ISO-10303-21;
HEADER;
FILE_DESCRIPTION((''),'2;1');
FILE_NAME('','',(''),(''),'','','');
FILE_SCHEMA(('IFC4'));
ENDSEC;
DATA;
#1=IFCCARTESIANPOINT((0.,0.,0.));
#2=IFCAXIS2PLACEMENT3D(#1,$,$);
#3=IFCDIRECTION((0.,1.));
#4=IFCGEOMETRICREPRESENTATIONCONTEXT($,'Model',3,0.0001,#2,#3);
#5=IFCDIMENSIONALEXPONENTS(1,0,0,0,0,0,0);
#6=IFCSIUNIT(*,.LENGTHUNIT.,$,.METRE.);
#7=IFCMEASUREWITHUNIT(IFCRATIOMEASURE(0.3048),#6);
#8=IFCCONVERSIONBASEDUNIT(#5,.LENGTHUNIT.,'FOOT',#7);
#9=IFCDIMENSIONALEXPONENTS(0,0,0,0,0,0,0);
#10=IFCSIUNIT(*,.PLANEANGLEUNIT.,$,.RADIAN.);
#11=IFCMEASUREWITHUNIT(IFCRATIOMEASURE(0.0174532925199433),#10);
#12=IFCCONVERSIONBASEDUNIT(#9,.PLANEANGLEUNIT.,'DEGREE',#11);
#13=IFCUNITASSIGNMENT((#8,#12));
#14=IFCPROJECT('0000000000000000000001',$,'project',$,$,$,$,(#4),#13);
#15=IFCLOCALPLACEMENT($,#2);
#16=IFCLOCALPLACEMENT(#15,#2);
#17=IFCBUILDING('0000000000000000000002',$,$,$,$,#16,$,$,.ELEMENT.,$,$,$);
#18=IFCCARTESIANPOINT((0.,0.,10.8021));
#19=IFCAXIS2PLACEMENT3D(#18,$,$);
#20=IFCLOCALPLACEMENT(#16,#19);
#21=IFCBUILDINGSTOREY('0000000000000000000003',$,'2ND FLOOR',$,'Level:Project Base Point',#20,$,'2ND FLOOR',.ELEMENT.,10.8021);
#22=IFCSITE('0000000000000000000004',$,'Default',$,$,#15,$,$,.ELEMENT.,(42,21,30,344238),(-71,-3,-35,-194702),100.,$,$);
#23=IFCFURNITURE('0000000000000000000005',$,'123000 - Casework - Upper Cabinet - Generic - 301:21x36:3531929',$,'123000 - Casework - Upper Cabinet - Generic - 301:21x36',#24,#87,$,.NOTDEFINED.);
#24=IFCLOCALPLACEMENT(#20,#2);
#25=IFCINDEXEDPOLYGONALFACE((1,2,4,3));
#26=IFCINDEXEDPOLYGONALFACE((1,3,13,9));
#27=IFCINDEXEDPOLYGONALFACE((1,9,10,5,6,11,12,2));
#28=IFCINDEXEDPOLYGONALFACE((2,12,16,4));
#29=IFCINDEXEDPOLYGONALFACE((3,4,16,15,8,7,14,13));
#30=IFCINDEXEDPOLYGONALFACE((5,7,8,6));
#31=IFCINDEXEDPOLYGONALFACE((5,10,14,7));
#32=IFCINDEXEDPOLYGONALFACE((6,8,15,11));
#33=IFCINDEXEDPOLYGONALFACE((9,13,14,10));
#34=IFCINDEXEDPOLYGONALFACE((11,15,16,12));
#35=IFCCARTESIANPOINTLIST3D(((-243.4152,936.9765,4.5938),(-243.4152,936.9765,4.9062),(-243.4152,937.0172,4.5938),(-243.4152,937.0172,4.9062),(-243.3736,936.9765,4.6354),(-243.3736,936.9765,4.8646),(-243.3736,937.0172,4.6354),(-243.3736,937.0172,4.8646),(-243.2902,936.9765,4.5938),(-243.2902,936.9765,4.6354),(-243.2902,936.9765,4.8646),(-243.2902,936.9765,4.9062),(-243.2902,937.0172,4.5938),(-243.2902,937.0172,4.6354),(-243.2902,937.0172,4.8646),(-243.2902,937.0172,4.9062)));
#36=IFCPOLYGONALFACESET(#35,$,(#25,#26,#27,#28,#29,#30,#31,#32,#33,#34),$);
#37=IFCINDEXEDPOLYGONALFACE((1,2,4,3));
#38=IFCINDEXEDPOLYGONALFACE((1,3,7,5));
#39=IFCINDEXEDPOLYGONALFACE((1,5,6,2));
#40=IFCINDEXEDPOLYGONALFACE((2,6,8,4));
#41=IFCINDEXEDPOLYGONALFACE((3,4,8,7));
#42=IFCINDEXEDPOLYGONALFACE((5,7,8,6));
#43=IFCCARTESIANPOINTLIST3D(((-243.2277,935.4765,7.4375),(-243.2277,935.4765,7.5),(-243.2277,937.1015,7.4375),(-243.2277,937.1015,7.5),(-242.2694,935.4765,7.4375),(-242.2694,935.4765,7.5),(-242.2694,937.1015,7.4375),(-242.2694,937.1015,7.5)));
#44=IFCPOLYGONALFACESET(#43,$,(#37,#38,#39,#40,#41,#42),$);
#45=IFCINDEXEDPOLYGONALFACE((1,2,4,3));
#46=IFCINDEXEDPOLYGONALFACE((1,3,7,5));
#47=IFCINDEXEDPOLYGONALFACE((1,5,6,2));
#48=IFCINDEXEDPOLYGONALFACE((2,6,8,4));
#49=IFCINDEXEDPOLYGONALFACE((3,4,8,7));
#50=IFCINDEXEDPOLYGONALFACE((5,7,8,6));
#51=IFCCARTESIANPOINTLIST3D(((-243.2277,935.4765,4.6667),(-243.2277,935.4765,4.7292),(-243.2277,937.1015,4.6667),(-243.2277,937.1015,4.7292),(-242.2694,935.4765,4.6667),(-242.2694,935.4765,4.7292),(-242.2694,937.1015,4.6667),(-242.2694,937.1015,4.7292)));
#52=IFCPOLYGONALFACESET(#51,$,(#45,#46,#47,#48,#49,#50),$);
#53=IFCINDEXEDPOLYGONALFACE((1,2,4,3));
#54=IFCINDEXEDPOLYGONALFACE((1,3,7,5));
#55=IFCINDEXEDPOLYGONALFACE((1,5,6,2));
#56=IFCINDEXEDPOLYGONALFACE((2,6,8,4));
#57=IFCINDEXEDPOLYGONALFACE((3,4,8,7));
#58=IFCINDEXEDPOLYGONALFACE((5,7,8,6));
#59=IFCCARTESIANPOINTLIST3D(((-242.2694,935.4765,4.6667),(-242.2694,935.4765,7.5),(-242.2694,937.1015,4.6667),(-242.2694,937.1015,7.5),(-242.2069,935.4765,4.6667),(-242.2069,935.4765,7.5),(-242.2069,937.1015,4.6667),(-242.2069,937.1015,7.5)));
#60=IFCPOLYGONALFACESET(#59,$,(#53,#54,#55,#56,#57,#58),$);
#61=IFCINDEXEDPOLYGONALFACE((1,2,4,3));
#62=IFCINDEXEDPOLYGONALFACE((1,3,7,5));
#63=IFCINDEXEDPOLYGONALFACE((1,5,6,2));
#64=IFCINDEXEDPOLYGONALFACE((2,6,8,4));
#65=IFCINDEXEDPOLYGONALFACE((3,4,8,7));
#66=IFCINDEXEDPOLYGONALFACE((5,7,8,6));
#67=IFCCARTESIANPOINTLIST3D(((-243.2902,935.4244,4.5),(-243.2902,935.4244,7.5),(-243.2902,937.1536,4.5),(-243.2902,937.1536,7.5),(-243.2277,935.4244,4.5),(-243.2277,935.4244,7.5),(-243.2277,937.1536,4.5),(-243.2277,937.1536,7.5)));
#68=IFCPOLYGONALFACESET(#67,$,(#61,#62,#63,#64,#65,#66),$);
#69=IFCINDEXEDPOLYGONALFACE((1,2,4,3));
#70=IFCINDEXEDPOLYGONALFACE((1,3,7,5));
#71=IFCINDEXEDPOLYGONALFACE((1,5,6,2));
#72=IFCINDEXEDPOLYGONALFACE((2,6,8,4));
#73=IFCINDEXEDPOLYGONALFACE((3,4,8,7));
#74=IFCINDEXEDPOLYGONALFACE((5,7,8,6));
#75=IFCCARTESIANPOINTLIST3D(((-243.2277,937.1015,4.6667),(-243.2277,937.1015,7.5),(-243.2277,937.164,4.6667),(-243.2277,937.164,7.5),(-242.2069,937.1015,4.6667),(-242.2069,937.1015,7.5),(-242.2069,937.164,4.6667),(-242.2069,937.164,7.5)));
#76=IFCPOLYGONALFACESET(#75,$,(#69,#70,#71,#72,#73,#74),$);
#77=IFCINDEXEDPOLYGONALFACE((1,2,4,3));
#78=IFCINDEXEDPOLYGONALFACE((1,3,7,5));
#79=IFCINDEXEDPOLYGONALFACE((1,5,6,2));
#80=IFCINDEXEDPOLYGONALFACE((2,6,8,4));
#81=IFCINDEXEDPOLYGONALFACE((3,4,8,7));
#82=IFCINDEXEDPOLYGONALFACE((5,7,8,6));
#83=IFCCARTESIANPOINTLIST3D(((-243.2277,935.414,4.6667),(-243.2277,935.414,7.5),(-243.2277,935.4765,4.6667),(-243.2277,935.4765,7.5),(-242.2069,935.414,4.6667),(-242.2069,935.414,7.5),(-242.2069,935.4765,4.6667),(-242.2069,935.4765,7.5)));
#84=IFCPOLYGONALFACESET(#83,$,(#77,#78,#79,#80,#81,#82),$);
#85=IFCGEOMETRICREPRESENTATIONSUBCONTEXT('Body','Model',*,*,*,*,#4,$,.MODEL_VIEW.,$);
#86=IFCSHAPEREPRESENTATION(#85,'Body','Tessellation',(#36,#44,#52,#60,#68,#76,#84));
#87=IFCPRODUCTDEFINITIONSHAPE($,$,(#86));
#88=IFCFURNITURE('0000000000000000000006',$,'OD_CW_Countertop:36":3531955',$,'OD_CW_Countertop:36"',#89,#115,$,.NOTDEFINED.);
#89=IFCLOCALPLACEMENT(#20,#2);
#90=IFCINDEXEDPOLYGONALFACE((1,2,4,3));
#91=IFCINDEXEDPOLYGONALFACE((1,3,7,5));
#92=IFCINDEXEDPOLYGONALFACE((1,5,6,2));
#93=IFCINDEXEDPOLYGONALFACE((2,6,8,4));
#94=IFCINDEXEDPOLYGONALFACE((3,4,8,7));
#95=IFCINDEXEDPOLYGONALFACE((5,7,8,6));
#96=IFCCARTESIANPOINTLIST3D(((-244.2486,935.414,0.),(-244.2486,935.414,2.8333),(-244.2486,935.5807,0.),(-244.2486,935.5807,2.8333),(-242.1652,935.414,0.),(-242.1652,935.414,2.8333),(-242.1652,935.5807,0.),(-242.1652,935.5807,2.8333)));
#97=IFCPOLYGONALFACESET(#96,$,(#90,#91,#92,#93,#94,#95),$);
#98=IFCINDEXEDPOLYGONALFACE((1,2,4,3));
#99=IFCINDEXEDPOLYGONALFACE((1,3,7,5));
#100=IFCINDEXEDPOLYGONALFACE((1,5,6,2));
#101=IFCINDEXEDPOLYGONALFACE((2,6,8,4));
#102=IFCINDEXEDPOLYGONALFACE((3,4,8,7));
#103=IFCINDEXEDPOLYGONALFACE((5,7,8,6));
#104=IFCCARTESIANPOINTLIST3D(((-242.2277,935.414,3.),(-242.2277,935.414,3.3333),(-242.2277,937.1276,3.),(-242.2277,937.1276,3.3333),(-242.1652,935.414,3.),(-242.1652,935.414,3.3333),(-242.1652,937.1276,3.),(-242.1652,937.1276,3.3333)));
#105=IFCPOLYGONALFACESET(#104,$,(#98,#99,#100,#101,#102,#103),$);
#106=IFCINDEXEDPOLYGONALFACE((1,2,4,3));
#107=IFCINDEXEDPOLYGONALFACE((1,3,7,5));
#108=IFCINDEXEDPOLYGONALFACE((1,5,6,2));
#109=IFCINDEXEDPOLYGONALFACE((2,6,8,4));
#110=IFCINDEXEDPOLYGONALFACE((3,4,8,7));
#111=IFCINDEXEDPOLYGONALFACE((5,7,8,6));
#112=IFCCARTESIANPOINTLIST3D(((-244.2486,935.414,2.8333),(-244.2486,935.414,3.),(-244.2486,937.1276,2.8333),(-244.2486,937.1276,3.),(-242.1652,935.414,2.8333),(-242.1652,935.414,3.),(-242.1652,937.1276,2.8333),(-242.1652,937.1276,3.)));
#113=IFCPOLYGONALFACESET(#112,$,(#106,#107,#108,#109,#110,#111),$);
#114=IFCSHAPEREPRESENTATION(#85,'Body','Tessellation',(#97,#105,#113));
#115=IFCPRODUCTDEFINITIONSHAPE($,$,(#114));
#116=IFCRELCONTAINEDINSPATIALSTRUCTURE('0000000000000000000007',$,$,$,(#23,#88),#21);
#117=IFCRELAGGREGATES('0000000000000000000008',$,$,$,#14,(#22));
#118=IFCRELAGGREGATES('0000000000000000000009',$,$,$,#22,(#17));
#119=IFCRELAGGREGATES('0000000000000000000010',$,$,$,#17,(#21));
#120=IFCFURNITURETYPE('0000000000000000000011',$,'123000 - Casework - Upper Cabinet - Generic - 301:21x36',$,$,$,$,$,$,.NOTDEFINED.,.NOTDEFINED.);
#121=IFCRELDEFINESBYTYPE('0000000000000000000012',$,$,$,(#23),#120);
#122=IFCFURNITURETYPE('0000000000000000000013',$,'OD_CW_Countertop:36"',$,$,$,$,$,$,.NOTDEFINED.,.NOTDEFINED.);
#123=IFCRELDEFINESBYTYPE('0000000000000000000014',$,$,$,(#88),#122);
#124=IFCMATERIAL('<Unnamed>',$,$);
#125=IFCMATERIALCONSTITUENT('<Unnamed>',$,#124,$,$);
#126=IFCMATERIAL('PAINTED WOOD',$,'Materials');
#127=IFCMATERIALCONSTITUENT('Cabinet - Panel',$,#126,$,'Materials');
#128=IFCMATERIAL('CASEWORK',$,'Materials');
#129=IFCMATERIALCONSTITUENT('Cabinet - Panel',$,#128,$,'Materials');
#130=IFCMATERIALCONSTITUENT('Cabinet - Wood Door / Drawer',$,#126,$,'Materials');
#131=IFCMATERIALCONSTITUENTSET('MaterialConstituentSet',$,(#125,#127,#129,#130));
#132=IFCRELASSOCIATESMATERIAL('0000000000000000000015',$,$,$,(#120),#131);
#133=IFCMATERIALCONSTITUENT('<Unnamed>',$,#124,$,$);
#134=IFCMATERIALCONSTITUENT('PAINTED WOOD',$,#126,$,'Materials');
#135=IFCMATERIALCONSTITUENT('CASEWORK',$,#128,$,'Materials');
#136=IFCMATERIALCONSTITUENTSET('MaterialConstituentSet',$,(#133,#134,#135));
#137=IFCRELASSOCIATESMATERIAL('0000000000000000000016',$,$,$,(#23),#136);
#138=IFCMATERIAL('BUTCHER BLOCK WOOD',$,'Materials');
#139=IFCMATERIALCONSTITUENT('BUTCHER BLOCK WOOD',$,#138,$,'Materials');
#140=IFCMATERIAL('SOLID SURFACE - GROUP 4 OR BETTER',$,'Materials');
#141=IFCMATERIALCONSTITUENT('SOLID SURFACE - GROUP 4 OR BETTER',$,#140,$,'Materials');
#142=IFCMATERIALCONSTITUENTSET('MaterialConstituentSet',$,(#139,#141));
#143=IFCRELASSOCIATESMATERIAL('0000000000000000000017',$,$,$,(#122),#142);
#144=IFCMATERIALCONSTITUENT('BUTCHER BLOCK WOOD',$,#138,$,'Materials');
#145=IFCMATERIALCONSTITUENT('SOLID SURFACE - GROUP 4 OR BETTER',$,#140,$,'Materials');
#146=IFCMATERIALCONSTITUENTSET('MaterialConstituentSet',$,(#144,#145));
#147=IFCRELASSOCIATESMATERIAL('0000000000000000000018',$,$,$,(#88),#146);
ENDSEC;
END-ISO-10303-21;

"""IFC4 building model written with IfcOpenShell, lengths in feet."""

from ifc_helpers import new_model, entity, si_unit, converted_unit, direction, frame, frame_2d, origin, origin_2d_with_axis, place, context, subcontext, project, spatial, polyline, rectangle, outline, extrude, source, transform, mapped, material, constituent, constituent_set, type_object, type_shapes, element, save


model = new_model("IFC4")

# Units and contexts
model_context = context("Model", 3, precision=0.0001, world=origin(), true_north=direction((0.0, 1.0)))
body_context = subcontext(model_context, "Body", "Model", "MODEL_VIEW")
ifc_project = project(units=[converted_unit("LENGTHUNIT", "FOOT", entity("IfcRatioMeasure", 0.3048), si_unit("LENGTHUNIT", "METRE"), dimensions=[1, 0, 0, 0, 0, 0, 0]), converted_unit("PLANEANGLEUNIT", "DEGREE", entity("IfcRatioMeasure", 0.0174532925199433), si_unit("PLANEANGLEUNIT", "RADIAN"), dimensions=[0, 0, 0, 0, 0, 0, 0])], contexts=[model_context])

# Site, building, storey
site_placement = place(None, origin())
site = spatial("IfcSite", under=ifc_project, at=site_placement, Name="Default", CompositionType="ELEMENT", RefLatitude=(42, 21, 30, 344238), RefLongitude=(-71, -3, -35, -194702), RefElevation=100.0)
building_placement = place(site_placement, origin())
building = spatial("IfcBuilding", under=site, at=building_placement, CompositionType="ELEMENT")
storey_placement = place(building_placement, frame((0.0, 0.0, 10.8021)))
storey = spatial("IfcBuildingStorey", under=building, at=storey_placement, Name="2ND FLOOR", ObjectType="Level:Project Base Point", LongName="2ND FLOOR", CompositionType="ELEMENT", Elevation=10.8021)

# Furniture
ifc_material_1 = material(Name="CASEWORK", Category="Materials")
ifc_material_2 = material(Name="<Unnamed>")
ifc_material_3 = material(Name="PAINTED WOOD", Category="Materials")
ifc_material_4 = material(Name="SOLID SURFACE - GROUP 4 OR BETTER", Category="Materials")
ifc_material_5 = material(Name="BUTCHER BLOCK WOOD", Category="Materials")
ifc_constituent_1 = constituent(ifc_material_2, Name="<Unnamed>")
ifc_constituent_2 = constituent(ifc_material_3, Name="PAINTED WOOD", Category="Materials")
ifc_constituent_3 = constituent(ifc_material_1, Name="CASEWORK", Category="Materials")
ifc_constituent_set_1 = constituent_set(constituents=[ifc_constituent_1, ifc_constituent_2, ifc_constituent_3], Name="MaterialConstituentSet")
ifc_constituent_4 = constituent(ifc_material_2, Name="<Unnamed>")
ifc_constituent_5 = constituent(ifc_material_3, Name="Cabinet - Panel", Category="Materials")
ifc_constituent_6 = constituent(ifc_material_1, Name="Cabinet - Panel", Category="Materials")
ifc_constituent_7 = constituent(ifc_material_3, Name="Cabinet - Wood Door / Drawer", Category="Materials")
ifc_constituent_set_2 = constituent_set(constituents=[ifc_constituent_4, ifc_constituent_5, ifc_constituent_6, ifc_constituent_7], Name="MaterialConstituentSet")
furniture_type_1 = type_object("IfcFurnitureType", Name="123000 - Casework - Upper Cabinet - Generic - 301:21x36", AssemblyPlace="NOTDEFINED", PredefinedType="NOTDEFINED", material=ifc_constituent_set_2)
shared_shape_1 = source(origin(), body_context, "Body", "SweptSolid", [
    extrude(outline(polyline([(0.1146, -0.0521), (0.1562, -0.0521), (0.1562, 0.0729), (-0.1562, 0.0729), (-0.1562, -0.0521), (-0.1146, -0.0521), (-0.1146, 0.0313), (0.1146, 0.0313), (0.1146, -0.0521)])), frame((0.1468, 0.0729, 0.25), z_axis=(1.0, 0.0, 0.0), x_axis=(0.0, 0.0, 1.0)), (0.0, 0.0, 1.0), 0.0407),
    extrude(rectangle(XDim=1.625, YDim=0.9583, at=frame_2d((0.0, 0.0), x_axis=(1.0, 0.0))), frame((0.875, 0.6666, 2.9375), z_axis=(0.0, 0.0, 1.0), x_axis=(-1.0, 0.0, 0.0)), (0.0, 0.0, 1.0), 0.0625),
    extrude(rectangle(XDim=1.625, YDim=0.9583, at=frame_2d((0.0, 0.0), x_axis=(1.0, 0.0))), frame((0.875, 0.6666, 0.1667), z_axis=(0.0, 0.0, 1.0), x_axis=(-1.0, 0.0, 0.0)), (0.0, 0.0, 1.0), 0.0625),
    extrude(rectangle(XDim=0.0625, YDim=1.625, at=origin_2d_with_axis()), frame((0.875, 1.177, 0.1667), z_axis=(0.0, 0.0, 1.0), x_axis=(0.0, 1.0, 0.0)), (0.0, 0.0, 1.0), 2.8333),
    extrude(rectangle(XDim=0.0625, YDim=1.7292, at=frame_2d((0.0, 0.0), x_axis=(1.0, 0.0))), frame((0.875, 0.1562, 0.0), z_axis=(0.0, 0.0, 1.0), x_axis=(0.0, -1.0, 0.0)), (0.0, 0.0, 1.0), 3.0),
    extrude(rectangle(XDim=0.0625, YDim=1.0208, at=origin_2d_with_axis()), frame((0.0312, 0.6979, 0.1667), z_axis=(0.0, 0.0, 1.0), x_axis=(-1.0, 0.0, 0.0)), (0.0, 0.0, 1.0), 2.8333),
    extrude(rectangle(XDim=0.0625, YDim=1.0208, at=origin_2d_with_axis()), frame((1.7188, 0.6979, 0.1667), z_axis=(0.0, 0.0, 1.0), x_axis=(-1.0, 0.0, 0.0)), (0.0, 0.0, 1.0), 2.8333),
])
type_shapes(furniture_type_1, [shared_shape_1])
furniture_1_placement = place(storey_placement, frame((-243.4152, 937.164, 4.5), z_axis=(0.0, 0.0, 1.0), x_axis=(0.0, -1.0, 0.0)))
element("IfcFurniture", 1, at=furniture_1_placement, inside=storey, type_object=furniture_type_1, material=ifc_constituent_set_1, Name="123000 - Casework - Upper Cabinet - Generic - 301:21x36:3531929", ObjectType="123000 - Casework - Upper Cabinet - Generic - 301:21x36", PredefinedType="NOTDEFINED", context=body_context, shape_type="MappedRepresentation", body=[
    mapped(shared_shape_1, transform((0.0, 0.0, 0.0), scale=1.0)),
])
ifc_constituent_8 = constituent(ifc_material_5, Name="BUTCHER BLOCK WOOD", Category="Materials")
ifc_constituent_9 = constituent(ifc_material_4, Name="SOLID SURFACE - GROUP 4 OR BETTER", Category="Materials")
ifc_constituent_set_3 = constituent_set(constituents=[ifc_constituent_8, ifc_constituent_9], Name="MaterialConstituentSet")
ifc_constituent_10 = constituent(ifc_material_5, Name="BUTCHER BLOCK WOOD", Category="Materials")
ifc_constituent_11 = constituent(ifc_material_4, Name="SOLID SURFACE - GROUP 4 OR BETTER", Category="Materials")
ifc_constituent_set_4 = constituent_set(constituents=[ifc_constituent_10, ifc_constituent_11], Name="MaterialConstituentSet")
furniture_type_2 = type_object("IfcFurnitureType", Name="OD_CW_Countertop:36\"", AssemblyPlace="NOTDEFINED", PredefinedType="NOTDEFINED", material=ifc_constituent_set_4)
shared_shape_2 = source(origin(), body_context, "Body", "SweptSolid", [
    extrude(rectangle(XDim=0.1667, YDim=2.0833, at=frame_2d((0.0, 0.0), x_axis=(1.0, 0.0))), frame((0.0833, 1.0417, 0.0)), (0.0, 0.0, 1.0), 2.8333),
    extrude(rectangle(XDim=1.7135, YDim=0.0625, at=origin_2d_with_axis()), frame((0.8568, 0.0313, 3.0)), (0.0, 0.0, 1.0), 0.3333),
    extrude(rectangle(XDim=1.7135, YDim=2.0833, at=origin_2d_with_axis()), frame((0.8568, 1.0417, 2.8333)), (0.0, 0.0, 1.0), 0.1667),
])
type_shapes(furniture_type_2, [shared_shape_2])
furniture_2_placement = place(storey_placement, frame((-242.1652, 935.414, 0.0), z_axis=(0.0, 0.0, 1.0), x_axis=(0.0, 1.0, 0.0)))
element("IfcFurniture", 2, at=furniture_2_placement, inside=storey, type_object=furniture_type_2, material=ifc_constituent_set_3, Name="OD_CW_Countertop:36\":3531955", ObjectType="OD_CW_Countertop:36\"", PredefinedType="NOTDEFINED", context=body_context, shape_type="MappedRepresentation", body=[
    mapped(shared_shape_2, transform((0.0, 0.0, 0.0), scale=1.0)),
])

save(model, "model.ifc")
